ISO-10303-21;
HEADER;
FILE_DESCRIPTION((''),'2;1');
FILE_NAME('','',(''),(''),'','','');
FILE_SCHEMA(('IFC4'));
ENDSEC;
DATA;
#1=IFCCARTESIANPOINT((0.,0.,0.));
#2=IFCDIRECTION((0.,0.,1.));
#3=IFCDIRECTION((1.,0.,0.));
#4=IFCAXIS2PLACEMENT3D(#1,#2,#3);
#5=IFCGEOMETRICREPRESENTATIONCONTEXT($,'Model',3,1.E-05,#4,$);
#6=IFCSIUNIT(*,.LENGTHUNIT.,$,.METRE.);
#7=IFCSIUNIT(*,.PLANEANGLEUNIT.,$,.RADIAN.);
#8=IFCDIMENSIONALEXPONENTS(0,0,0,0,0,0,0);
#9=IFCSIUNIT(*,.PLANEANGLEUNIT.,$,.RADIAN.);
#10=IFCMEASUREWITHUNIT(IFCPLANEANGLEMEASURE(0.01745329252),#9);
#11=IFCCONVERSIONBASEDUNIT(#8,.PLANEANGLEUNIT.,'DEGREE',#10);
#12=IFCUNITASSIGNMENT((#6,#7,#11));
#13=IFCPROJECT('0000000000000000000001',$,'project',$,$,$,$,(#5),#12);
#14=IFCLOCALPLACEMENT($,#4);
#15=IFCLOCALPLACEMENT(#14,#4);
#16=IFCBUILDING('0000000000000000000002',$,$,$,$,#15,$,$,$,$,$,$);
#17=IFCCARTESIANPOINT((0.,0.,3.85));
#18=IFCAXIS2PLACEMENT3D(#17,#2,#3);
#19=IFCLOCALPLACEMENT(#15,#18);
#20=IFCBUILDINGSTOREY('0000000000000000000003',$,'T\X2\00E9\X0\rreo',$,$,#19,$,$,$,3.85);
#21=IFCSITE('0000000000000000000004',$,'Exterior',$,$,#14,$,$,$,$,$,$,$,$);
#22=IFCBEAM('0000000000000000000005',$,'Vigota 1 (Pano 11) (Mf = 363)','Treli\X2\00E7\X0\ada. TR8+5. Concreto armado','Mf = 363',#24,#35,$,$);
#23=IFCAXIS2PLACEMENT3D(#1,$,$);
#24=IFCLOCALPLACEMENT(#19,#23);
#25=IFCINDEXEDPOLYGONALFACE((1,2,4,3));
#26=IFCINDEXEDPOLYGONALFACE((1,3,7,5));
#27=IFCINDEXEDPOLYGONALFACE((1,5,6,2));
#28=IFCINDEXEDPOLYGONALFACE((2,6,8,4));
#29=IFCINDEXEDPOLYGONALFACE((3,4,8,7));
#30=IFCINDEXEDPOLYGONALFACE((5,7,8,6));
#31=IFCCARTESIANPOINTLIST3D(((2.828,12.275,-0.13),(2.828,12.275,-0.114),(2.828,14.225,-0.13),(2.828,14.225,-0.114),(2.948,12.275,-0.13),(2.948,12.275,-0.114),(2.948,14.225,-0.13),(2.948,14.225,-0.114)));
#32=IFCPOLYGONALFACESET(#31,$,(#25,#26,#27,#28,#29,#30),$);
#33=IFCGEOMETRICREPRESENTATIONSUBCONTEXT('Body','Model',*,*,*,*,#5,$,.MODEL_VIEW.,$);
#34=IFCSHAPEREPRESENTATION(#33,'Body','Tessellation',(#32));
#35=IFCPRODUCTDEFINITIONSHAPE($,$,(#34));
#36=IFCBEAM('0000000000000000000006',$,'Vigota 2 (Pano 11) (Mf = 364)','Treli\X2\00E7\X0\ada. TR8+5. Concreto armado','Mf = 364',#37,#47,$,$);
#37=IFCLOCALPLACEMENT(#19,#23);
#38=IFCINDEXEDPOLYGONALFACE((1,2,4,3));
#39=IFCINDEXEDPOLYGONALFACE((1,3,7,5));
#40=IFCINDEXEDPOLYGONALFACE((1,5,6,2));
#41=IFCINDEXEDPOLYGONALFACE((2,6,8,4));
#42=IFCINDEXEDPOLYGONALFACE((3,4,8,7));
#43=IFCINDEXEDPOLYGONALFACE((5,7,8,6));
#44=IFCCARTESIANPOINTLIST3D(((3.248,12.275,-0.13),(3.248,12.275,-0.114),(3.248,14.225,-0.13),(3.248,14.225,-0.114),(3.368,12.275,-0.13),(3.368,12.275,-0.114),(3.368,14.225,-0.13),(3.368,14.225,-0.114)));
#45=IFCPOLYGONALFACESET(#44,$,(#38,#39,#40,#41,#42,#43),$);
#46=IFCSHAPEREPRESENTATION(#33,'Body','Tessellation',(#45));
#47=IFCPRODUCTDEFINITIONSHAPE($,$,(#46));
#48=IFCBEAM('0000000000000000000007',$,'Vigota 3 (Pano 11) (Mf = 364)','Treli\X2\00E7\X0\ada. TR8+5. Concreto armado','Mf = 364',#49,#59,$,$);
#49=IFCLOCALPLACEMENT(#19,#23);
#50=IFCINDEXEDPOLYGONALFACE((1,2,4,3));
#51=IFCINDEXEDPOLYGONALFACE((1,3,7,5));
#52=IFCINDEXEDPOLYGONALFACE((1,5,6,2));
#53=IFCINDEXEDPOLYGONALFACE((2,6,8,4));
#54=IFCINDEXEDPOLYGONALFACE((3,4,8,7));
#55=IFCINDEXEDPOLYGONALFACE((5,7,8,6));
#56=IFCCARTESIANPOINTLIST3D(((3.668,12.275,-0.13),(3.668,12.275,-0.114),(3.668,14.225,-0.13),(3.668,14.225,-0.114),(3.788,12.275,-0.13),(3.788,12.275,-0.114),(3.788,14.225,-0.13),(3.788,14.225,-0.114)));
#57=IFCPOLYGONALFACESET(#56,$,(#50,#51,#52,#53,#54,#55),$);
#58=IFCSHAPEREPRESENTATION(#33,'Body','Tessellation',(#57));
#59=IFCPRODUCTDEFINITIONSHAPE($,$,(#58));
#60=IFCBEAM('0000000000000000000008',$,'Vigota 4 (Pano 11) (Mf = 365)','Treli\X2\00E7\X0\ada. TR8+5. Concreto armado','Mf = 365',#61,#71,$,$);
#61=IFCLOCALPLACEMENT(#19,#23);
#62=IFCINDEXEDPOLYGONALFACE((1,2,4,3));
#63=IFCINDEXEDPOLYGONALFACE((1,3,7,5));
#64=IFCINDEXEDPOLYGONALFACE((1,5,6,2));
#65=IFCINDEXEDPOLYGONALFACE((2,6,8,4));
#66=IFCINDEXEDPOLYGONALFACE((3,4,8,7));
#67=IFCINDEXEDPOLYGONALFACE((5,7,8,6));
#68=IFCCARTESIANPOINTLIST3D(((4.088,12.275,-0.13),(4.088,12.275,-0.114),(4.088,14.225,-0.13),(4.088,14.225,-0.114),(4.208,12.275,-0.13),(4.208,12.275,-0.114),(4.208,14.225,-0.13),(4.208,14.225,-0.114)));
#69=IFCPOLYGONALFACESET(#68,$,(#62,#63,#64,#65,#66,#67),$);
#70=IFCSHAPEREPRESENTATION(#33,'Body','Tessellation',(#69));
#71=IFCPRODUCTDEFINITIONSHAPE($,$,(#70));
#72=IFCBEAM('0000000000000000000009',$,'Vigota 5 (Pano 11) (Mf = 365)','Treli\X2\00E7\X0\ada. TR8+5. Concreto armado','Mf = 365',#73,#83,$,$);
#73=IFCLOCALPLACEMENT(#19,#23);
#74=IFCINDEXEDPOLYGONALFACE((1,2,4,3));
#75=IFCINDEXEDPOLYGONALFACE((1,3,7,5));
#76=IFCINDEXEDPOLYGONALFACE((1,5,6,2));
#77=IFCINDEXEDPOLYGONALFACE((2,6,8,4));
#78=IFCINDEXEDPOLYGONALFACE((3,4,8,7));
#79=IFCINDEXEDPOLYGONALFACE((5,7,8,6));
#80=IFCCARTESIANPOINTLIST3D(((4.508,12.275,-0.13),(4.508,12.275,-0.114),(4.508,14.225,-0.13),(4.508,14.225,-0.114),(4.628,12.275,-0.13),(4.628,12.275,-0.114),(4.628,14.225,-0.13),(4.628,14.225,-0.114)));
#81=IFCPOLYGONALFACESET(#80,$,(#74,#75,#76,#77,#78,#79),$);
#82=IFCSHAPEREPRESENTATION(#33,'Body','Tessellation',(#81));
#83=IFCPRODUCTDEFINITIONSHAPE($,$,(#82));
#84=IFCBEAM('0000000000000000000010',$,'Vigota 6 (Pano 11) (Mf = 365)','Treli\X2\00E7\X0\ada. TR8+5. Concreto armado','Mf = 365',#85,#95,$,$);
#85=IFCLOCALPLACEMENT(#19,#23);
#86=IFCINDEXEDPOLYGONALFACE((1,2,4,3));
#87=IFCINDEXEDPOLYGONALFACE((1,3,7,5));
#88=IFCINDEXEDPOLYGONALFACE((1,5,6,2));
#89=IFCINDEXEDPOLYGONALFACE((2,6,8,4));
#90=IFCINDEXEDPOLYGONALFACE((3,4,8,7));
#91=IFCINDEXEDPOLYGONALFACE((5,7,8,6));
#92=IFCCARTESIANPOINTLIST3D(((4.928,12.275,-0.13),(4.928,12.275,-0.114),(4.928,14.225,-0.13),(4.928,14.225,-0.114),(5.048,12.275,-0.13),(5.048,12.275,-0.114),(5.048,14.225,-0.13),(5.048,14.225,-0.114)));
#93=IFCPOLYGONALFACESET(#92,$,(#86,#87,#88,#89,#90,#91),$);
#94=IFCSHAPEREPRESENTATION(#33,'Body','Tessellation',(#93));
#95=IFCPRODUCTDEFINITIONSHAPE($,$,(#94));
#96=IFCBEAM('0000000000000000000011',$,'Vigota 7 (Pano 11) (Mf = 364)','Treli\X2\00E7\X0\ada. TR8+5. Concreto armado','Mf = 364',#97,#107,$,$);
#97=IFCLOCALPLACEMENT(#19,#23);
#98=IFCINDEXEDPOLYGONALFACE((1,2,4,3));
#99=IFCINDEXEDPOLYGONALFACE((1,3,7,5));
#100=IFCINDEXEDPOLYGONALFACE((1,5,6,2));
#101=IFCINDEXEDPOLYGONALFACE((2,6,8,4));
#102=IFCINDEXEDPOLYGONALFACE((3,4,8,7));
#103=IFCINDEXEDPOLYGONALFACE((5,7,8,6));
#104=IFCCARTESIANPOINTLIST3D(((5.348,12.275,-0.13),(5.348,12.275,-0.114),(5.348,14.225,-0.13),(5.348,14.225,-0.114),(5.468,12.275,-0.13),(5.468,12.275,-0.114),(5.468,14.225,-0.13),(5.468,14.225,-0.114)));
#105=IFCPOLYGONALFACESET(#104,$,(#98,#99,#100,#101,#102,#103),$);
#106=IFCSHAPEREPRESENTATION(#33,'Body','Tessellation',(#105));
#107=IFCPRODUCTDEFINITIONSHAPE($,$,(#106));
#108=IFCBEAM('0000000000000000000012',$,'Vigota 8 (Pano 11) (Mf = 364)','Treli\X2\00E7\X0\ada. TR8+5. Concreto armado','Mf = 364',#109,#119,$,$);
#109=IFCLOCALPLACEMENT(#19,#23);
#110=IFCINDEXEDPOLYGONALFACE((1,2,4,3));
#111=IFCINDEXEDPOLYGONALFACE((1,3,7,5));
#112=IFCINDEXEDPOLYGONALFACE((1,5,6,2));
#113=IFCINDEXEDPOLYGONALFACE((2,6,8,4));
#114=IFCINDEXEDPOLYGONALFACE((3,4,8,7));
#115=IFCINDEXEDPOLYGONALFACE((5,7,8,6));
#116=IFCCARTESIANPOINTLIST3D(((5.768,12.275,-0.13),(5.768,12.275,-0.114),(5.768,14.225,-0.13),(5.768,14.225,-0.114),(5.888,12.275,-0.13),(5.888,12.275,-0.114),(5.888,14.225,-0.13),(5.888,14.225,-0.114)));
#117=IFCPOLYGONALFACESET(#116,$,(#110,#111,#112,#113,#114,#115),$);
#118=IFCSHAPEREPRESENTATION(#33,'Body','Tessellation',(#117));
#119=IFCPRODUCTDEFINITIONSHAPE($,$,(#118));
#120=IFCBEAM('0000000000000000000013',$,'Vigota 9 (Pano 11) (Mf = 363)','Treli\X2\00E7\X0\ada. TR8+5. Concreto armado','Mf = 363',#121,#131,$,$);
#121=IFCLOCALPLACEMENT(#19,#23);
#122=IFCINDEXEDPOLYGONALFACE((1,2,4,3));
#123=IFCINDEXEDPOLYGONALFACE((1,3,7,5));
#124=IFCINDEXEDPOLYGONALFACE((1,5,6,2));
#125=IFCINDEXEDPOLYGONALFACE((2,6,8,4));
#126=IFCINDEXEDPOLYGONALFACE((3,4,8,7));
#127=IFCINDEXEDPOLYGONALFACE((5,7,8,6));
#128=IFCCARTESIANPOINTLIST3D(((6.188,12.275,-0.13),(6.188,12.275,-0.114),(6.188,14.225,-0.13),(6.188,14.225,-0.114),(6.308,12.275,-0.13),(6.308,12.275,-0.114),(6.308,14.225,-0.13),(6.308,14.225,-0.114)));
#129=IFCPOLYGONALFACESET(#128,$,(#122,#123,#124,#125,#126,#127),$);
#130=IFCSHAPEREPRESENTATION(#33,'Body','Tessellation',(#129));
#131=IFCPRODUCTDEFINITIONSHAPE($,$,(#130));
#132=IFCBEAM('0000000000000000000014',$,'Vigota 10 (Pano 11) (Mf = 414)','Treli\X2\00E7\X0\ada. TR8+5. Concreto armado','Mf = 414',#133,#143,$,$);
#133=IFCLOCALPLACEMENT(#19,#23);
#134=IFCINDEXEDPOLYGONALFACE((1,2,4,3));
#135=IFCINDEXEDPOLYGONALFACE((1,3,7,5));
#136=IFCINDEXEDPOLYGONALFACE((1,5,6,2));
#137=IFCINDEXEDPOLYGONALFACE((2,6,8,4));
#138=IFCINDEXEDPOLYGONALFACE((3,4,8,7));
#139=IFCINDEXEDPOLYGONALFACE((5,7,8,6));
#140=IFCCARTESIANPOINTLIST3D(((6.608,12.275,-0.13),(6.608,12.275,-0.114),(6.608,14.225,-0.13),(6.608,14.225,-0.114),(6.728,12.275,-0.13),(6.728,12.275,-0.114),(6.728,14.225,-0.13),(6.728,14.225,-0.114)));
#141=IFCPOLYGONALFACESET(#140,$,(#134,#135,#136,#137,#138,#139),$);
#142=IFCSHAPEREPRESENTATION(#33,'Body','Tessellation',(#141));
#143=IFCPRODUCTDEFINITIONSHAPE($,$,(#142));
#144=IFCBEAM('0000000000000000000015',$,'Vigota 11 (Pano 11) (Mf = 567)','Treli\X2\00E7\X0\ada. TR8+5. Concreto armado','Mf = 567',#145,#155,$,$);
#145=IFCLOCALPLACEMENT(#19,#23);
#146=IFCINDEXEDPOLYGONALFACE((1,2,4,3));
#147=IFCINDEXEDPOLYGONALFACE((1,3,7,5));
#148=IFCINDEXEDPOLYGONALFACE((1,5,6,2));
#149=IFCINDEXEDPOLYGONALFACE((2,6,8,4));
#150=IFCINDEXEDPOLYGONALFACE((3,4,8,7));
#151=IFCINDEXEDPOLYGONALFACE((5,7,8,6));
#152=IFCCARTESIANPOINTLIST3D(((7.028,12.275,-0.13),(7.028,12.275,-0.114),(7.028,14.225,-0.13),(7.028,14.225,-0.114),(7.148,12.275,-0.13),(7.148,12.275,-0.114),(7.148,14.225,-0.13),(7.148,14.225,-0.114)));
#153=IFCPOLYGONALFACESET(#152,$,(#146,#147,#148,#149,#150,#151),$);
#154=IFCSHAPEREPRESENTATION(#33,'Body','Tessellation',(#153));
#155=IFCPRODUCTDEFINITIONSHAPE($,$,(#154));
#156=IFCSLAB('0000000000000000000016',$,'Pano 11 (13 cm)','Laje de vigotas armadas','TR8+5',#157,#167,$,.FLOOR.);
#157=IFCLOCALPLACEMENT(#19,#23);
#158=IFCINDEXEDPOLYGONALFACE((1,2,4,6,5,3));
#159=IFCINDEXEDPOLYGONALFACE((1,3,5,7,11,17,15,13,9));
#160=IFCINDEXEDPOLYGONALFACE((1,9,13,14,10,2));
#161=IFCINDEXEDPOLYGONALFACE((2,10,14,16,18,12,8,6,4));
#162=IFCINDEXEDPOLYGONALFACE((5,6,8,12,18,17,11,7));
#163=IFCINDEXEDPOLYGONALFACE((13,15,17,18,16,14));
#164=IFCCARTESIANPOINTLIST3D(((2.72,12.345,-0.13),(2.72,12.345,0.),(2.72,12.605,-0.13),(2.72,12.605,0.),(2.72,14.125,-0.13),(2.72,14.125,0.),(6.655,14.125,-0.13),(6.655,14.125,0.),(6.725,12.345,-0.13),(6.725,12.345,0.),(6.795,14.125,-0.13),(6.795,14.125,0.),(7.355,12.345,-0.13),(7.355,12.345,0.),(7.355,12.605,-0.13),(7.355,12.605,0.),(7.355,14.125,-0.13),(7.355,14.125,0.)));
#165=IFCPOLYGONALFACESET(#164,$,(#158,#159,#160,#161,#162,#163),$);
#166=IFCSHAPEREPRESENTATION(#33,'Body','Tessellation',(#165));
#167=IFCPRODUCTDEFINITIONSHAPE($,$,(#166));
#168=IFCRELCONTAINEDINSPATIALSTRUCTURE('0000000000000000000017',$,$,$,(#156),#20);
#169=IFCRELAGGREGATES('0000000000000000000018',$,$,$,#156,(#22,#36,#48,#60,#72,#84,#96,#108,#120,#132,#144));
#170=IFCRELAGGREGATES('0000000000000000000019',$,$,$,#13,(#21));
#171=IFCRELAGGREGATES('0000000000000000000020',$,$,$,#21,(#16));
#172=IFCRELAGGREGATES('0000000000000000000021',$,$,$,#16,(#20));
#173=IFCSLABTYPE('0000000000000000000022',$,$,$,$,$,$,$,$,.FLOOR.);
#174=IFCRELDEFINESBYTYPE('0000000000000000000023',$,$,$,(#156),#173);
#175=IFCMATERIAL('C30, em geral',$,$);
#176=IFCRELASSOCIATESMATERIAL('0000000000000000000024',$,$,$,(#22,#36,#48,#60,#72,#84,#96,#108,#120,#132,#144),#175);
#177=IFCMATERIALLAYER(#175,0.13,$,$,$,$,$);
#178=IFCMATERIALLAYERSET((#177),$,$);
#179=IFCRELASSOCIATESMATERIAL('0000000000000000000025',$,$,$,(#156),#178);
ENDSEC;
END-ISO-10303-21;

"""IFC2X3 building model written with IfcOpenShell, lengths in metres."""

from ifc_helpers import new_model, entity, si_unit, converted_unit, frame, origin_with_axes, place, context, subcontext, project, spatial, polyline, outline, extrude, material, layer, layer_set, layer_usage, type_object, element, aggregate, save


model = new_model("IFC2X3")

# Units and contexts
model_context = context("Model", 3, precision=1e-05, world=origin_with_axes())
body_context = subcontext(model_context, "Body", "Model", "MODEL_VIEW")
ifc_project = project(units=[si_unit("LENGTHUNIT", "METRE"), si_unit("PLANEANGLEUNIT", "RADIAN"), converted_unit("PLANEANGLEUNIT", "DEGREE", entity("IfcPlaneAngleMeasure", 0.01745329252), si_unit("PLANEANGLEUNIT", "RADIAN"), dimensions=[0, 0, 0, 0, 0, 0, 0])], contexts=[model_context])

# Site, building, storey
site_placement = place(None, origin_with_axes())
site = spatial("IfcSite", under=ifc_project, at=site_placement, Name="Exterior")
building_placement = place(site_placement, origin_with_axes())
building = spatial("IfcBuilding", under=site, at=building_placement)
storey_placement = place(building_placement, frame((0.0, 0.0, 3.85), z_axis=(0.0, 0.0, 1.0), x_axis=(1.0, 0.0, 0.0)))
storey = spatial("IfcBuildingStorey", under=building, at=storey_placement, Name="Térreo", Elevation=3.85)

# Beams
ifc_material_1 = material(Name="C30, em geral")
beam_1_placement = place(storey_placement, frame((2.888, 12.275, -0.122), z_axis=(0.0, 1.0, 0.0), x_axis=(-1.0, 0.0, 0.0)))
beam_1 = element("IfcBeam", 1, at=beam_1_placement, material=ifc_material_1, Name="Vigota 1 (Pano 11) (Mf = 363)", Description="Treliçada. TR8+5. Concreto armado", ObjectType="Mf = 363", context=body_context, shape_type="SweptSolid", body=[
    extrude(outline(polyline([(0.06, 0.008), (-0.06, 0.008), (-0.06, -0.008), (0.06, -0.008), (0.06, 0.008)])), origin_with_axes(), (0.0, 0.0, 1.0), 1.95),
])
beam_2_placement = place(storey_placement, frame((3.308, 12.275, -0.122), z_axis=(0.0, 1.0, 0.0), x_axis=(-1.0, 0.0, 0.0)))
beam_2 = element("IfcBeam", 2, at=beam_2_placement, material=ifc_material_1, Name="Vigota 2 (Pano 11) (Mf = 364)", Description="Treliçada. TR8+5. Concreto armado", ObjectType="Mf = 364", context=body_context, shape_type="SweptSolid", body=[
    extrude(outline(polyline([(0.06, 0.008), (-0.06, 0.008), (-0.06, -0.008), (0.06, -0.008), (0.06, 0.008)])), origin_with_axes(), (0.0, 0.0, 1.0), 1.95),
])
beam_3_placement = place(storey_placement, frame((3.728, 12.275, -0.122), z_axis=(0.0, 1.0, 0.0), x_axis=(-1.0, 0.0, 0.0)))
beam_3 = element("IfcBeam", 3, at=beam_3_placement, material=ifc_material_1, Name="Vigota 3 (Pano 11) (Mf = 364)", Description="Treliçada. TR8+5. Concreto armado", ObjectType="Mf = 364", context=body_context, shape_type="SweptSolid", body=[
    extrude(outline(polyline([(0.06, 0.008), (-0.06, 0.008), (-0.06, -0.008), (0.06, -0.008), (0.06, 0.008)])), origin_with_axes(), (0.0, 0.0, 1.0), 1.95),
])
beam_4_placement = place(storey_placement, frame((4.148, 12.275, -0.122), z_axis=(0.0, 1.0, 0.0), x_axis=(-1.0, 0.0, 0.0)))
beam_4 = element("IfcBeam", 4, at=beam_4_placement, material=ifc_material_1, Name="Vigota 4 (Pano 11) (Mf = 365)", Description="Treliçada. TR8+5. Concreto armado", ObjectType="Mf = 365", context=body_context, shape_type="SweptSolid", body=[
    extrude(outline(polyline([(0.06, 0.008), (-0.06, 0.008), (-0.06, -0.008), (0.06, -0.008), (0.06, 0.008)])), origin_with_axes(), (0.0, 0.0, 1.0), 1.95),
])
beam_5_placement = place(storey_placement, frame((4.568, 12.275, -0.122), z_axis=(0.0, 1.0, 0.0), x_axis=(-1.0, 0.0, 0.0)))
beam_5 = element("IfcBeam", 5, at=beam_5_placement, material=ifc_material_1, Name="Vigota 5 (Pano 11) (Mf = 365)", Description="Treliçada. TR8+5. Concreto armado", ObjectType="Mf = 365", context=body_context, shape_type="SweptSolid", body=[
    extrude(outline(polyline([(0.06, 0.008), (-0.06, 0.008), (-0.06, -0.008), (0.06, -0.008), (0.06, 0.008)])), origin_with_axes(), (0.0, 0.0, 1.0), 1.95),
])
beam_6_placement = place(storey_placement, frame((4.988, 12.275, -0.122), z_axis=(0.0, 1.0, 0.0), x_axis=(-1.0, 0.0, 0.0)))
beam_6 = element("IfcBeam", 6, at=beam_6_placement, material=ifc_material_1, Name="Vigota 6 (Pano 11) (Mf = 365)", Description="Treliçada. TR8+5. Concreto armado", ObjectType="Mf = 365", context=body_context, shape_type="SweptSolid", body=[
    extrude(outline(polyline([(0.06, 0.008), (-0.06, 0.008), (-0.06, -0.008), (0.06, -0.008), (0.06, 0.008)])), origin_with_axes(), (0.0, 0.0, 1.0), 1.95),
])
beam_7_placement = place(storey_placement, frame((5.408, 12.275, -0.122), z_axis=(0.0, 1.0, 0.0), x_axis=(-1.0, 0.0, 0.0)))
beam_7 = element("IfcBeam", 7, at=beam_7_placement, material=ifc_material_1, Name="Vigota 7 (Pano 11) (Mf = 364)", Description="Treliçada. TR8+5. Concreto armado", ObjectType="Mf = 364", context=body_context, shape_type="SweptSolid", body=[
    extrude(outline(polyline([(0.06, 0.008), (-0.06, 0.008), (-0.06, -0.008), (0.06, -0.008), (0.06, 0.008)])), origin_with_axes(), (0.0, 0.0, 1.0), 1.95),
])
beam_8_placement = place(storey_placement, frame((5.828, 12.275, -0.122), z_axis=(0.0, 1.0, 0.0), x_axis=(-1.0, 0.0, 0.0)))
beam_8 = element("IfcBeam", 8, at=beam_8_placement, material=ifc_material_1, Name="Vigota 8 (Pano 11) (Mf = 364)", Description="Treliçada. TR8+5. Concreto armado", ObjectType="Mf = 364", context=body_context, shape_type="SweptSolid", body=[
    extrude(outline(polyline([(0.06, 0.008), (-0.06, 0.008), (-0.06, -0.008), (0.06, -0.008), (0.06, 0.008)])), origin_with_axes(), (0.0, 0.0, 1.0), 1.95),
])
beam_9_placement = place(storey_placement, frame((6.248, 12.275, -0.122), z_axis=(0.0, 1.0, 0.0), x_axis=(-1.0, 0.0, 0.0)))
beam_9 = element("IfcBeam", 9, at=beam_9_placement, material=ifc_material_1, Name="Vigota 9 (Pano 11) (Mf = 363)", Description="Treliçada. TR8+5. Concreto armado", ObjectType="Mf = 363", context=body_context, shape_type="SweptSolid", body=[
    extrude(outline(polyline([(0.06, 0.008), (-0.06, 0.008), (-0.06, -0.008), (0.06, -0.008), (0.06, 0.008)])), origin_with_axes(), (0.0, 0.0, 1.0), 1.95),
])
beam_10_placement = place(storey_placement, frame((6.668, 12.275, -0.122), z_axis=(0.0, 1.0, 0.0), x_axis=(-1.0, 0.0, 0.0)))
beam_10 = element("IfcBeam", 10, at=beam_10_placement, material=ifc_material_1, Name="Vigota 10 (Pano 11) (Mf = 414)", Description="Treliçada. TR8+5. Concreto armado", ObjectType="Mf = 414", context=body_context, shape_type="SweptSolid", body=[
    extrude(outline(polyline([(0.06, 0.008), (-0.06, 0.008), (-0.06, -0.008), (0.06, -0.008), (0.06, 0.008)])), origin_with_axes(), (0.0, 0.0, 1.0), 1.95),
])
beam_11_placement = place(storey_placement, frame((7.088, 12.275, -0.122), z_axis=(0.0, 1.0, 0.0), x_axis=(-1.0, 0.0, 0.0)))
beam_11 = element("IfcBeam", 11, at=beam_11_placement, material=ifc_material_1, Name="Vigota 11 (Pano 11) (Mf = 567)", Description="Treliçada. TR8+5. Concreto armado", ObjectType="Mf = 567", context=body_context, shape_type="SweptSolid", body=[
    extrude(outline(polyline([(0.06, 0.008), (-0.06, 0.008), (-0.06, -0.008), (0.06, -0.008), (0.06, 0.008)])), origin_with_axes(), (0.0, 0.0, 1.0), 1.95),
])

# Slab
ifc_layer_1 = layer(ifc_material_1, 0.13)
ifc_layer_set_1 = layer_set([ifc_layer_1])
ifc_layer_usage_1 = layer_usage(ifc_layer_set_1, "AXIS3", "POSITIVE", 0.0)
slab_type = type_object("IfcSlabType", PredefinedType="FLOOR")
slab_1_placement = place(storey_placement, frame((0.0, 0.0, -0.13), z_axis=(0.0, 0.0, 1.0), x_axis=(1.0, 0.0, 0.0)))
slab_1 = element("IfcSlab", 12, at=slab_1_placement, inside=storey, type_object=slab_type, material=ifc_layer_usage_1, Name="Pano 11 (13 cm)", Description="Laje de vigotas armadas", ObjectType="TR8+5", PredefinedType="FLOOR", context=body_context, shape_type="SweptSolid", body=[
    extrude(outline(polyline([(7.355, 12.345), (7.355, 12.605), (7.355, 14.125), (6.795, 14.125), (6.655, 14.125), (2.72, 14.125), (2.72, 12.605), (2.72, 12.345), (6.725, 12.345), (7.355, 12.345)])), origin_with_axes(), (0.0, 0.0, 1.0), 0.13),
])
aggregate(slab_1, [beam_1, beam_2, beam_3, beam_4, beam_5, beam_6, beam_7, beam_8, beam_9, beam_10, beam_11])

save(model, "model.ifc")
